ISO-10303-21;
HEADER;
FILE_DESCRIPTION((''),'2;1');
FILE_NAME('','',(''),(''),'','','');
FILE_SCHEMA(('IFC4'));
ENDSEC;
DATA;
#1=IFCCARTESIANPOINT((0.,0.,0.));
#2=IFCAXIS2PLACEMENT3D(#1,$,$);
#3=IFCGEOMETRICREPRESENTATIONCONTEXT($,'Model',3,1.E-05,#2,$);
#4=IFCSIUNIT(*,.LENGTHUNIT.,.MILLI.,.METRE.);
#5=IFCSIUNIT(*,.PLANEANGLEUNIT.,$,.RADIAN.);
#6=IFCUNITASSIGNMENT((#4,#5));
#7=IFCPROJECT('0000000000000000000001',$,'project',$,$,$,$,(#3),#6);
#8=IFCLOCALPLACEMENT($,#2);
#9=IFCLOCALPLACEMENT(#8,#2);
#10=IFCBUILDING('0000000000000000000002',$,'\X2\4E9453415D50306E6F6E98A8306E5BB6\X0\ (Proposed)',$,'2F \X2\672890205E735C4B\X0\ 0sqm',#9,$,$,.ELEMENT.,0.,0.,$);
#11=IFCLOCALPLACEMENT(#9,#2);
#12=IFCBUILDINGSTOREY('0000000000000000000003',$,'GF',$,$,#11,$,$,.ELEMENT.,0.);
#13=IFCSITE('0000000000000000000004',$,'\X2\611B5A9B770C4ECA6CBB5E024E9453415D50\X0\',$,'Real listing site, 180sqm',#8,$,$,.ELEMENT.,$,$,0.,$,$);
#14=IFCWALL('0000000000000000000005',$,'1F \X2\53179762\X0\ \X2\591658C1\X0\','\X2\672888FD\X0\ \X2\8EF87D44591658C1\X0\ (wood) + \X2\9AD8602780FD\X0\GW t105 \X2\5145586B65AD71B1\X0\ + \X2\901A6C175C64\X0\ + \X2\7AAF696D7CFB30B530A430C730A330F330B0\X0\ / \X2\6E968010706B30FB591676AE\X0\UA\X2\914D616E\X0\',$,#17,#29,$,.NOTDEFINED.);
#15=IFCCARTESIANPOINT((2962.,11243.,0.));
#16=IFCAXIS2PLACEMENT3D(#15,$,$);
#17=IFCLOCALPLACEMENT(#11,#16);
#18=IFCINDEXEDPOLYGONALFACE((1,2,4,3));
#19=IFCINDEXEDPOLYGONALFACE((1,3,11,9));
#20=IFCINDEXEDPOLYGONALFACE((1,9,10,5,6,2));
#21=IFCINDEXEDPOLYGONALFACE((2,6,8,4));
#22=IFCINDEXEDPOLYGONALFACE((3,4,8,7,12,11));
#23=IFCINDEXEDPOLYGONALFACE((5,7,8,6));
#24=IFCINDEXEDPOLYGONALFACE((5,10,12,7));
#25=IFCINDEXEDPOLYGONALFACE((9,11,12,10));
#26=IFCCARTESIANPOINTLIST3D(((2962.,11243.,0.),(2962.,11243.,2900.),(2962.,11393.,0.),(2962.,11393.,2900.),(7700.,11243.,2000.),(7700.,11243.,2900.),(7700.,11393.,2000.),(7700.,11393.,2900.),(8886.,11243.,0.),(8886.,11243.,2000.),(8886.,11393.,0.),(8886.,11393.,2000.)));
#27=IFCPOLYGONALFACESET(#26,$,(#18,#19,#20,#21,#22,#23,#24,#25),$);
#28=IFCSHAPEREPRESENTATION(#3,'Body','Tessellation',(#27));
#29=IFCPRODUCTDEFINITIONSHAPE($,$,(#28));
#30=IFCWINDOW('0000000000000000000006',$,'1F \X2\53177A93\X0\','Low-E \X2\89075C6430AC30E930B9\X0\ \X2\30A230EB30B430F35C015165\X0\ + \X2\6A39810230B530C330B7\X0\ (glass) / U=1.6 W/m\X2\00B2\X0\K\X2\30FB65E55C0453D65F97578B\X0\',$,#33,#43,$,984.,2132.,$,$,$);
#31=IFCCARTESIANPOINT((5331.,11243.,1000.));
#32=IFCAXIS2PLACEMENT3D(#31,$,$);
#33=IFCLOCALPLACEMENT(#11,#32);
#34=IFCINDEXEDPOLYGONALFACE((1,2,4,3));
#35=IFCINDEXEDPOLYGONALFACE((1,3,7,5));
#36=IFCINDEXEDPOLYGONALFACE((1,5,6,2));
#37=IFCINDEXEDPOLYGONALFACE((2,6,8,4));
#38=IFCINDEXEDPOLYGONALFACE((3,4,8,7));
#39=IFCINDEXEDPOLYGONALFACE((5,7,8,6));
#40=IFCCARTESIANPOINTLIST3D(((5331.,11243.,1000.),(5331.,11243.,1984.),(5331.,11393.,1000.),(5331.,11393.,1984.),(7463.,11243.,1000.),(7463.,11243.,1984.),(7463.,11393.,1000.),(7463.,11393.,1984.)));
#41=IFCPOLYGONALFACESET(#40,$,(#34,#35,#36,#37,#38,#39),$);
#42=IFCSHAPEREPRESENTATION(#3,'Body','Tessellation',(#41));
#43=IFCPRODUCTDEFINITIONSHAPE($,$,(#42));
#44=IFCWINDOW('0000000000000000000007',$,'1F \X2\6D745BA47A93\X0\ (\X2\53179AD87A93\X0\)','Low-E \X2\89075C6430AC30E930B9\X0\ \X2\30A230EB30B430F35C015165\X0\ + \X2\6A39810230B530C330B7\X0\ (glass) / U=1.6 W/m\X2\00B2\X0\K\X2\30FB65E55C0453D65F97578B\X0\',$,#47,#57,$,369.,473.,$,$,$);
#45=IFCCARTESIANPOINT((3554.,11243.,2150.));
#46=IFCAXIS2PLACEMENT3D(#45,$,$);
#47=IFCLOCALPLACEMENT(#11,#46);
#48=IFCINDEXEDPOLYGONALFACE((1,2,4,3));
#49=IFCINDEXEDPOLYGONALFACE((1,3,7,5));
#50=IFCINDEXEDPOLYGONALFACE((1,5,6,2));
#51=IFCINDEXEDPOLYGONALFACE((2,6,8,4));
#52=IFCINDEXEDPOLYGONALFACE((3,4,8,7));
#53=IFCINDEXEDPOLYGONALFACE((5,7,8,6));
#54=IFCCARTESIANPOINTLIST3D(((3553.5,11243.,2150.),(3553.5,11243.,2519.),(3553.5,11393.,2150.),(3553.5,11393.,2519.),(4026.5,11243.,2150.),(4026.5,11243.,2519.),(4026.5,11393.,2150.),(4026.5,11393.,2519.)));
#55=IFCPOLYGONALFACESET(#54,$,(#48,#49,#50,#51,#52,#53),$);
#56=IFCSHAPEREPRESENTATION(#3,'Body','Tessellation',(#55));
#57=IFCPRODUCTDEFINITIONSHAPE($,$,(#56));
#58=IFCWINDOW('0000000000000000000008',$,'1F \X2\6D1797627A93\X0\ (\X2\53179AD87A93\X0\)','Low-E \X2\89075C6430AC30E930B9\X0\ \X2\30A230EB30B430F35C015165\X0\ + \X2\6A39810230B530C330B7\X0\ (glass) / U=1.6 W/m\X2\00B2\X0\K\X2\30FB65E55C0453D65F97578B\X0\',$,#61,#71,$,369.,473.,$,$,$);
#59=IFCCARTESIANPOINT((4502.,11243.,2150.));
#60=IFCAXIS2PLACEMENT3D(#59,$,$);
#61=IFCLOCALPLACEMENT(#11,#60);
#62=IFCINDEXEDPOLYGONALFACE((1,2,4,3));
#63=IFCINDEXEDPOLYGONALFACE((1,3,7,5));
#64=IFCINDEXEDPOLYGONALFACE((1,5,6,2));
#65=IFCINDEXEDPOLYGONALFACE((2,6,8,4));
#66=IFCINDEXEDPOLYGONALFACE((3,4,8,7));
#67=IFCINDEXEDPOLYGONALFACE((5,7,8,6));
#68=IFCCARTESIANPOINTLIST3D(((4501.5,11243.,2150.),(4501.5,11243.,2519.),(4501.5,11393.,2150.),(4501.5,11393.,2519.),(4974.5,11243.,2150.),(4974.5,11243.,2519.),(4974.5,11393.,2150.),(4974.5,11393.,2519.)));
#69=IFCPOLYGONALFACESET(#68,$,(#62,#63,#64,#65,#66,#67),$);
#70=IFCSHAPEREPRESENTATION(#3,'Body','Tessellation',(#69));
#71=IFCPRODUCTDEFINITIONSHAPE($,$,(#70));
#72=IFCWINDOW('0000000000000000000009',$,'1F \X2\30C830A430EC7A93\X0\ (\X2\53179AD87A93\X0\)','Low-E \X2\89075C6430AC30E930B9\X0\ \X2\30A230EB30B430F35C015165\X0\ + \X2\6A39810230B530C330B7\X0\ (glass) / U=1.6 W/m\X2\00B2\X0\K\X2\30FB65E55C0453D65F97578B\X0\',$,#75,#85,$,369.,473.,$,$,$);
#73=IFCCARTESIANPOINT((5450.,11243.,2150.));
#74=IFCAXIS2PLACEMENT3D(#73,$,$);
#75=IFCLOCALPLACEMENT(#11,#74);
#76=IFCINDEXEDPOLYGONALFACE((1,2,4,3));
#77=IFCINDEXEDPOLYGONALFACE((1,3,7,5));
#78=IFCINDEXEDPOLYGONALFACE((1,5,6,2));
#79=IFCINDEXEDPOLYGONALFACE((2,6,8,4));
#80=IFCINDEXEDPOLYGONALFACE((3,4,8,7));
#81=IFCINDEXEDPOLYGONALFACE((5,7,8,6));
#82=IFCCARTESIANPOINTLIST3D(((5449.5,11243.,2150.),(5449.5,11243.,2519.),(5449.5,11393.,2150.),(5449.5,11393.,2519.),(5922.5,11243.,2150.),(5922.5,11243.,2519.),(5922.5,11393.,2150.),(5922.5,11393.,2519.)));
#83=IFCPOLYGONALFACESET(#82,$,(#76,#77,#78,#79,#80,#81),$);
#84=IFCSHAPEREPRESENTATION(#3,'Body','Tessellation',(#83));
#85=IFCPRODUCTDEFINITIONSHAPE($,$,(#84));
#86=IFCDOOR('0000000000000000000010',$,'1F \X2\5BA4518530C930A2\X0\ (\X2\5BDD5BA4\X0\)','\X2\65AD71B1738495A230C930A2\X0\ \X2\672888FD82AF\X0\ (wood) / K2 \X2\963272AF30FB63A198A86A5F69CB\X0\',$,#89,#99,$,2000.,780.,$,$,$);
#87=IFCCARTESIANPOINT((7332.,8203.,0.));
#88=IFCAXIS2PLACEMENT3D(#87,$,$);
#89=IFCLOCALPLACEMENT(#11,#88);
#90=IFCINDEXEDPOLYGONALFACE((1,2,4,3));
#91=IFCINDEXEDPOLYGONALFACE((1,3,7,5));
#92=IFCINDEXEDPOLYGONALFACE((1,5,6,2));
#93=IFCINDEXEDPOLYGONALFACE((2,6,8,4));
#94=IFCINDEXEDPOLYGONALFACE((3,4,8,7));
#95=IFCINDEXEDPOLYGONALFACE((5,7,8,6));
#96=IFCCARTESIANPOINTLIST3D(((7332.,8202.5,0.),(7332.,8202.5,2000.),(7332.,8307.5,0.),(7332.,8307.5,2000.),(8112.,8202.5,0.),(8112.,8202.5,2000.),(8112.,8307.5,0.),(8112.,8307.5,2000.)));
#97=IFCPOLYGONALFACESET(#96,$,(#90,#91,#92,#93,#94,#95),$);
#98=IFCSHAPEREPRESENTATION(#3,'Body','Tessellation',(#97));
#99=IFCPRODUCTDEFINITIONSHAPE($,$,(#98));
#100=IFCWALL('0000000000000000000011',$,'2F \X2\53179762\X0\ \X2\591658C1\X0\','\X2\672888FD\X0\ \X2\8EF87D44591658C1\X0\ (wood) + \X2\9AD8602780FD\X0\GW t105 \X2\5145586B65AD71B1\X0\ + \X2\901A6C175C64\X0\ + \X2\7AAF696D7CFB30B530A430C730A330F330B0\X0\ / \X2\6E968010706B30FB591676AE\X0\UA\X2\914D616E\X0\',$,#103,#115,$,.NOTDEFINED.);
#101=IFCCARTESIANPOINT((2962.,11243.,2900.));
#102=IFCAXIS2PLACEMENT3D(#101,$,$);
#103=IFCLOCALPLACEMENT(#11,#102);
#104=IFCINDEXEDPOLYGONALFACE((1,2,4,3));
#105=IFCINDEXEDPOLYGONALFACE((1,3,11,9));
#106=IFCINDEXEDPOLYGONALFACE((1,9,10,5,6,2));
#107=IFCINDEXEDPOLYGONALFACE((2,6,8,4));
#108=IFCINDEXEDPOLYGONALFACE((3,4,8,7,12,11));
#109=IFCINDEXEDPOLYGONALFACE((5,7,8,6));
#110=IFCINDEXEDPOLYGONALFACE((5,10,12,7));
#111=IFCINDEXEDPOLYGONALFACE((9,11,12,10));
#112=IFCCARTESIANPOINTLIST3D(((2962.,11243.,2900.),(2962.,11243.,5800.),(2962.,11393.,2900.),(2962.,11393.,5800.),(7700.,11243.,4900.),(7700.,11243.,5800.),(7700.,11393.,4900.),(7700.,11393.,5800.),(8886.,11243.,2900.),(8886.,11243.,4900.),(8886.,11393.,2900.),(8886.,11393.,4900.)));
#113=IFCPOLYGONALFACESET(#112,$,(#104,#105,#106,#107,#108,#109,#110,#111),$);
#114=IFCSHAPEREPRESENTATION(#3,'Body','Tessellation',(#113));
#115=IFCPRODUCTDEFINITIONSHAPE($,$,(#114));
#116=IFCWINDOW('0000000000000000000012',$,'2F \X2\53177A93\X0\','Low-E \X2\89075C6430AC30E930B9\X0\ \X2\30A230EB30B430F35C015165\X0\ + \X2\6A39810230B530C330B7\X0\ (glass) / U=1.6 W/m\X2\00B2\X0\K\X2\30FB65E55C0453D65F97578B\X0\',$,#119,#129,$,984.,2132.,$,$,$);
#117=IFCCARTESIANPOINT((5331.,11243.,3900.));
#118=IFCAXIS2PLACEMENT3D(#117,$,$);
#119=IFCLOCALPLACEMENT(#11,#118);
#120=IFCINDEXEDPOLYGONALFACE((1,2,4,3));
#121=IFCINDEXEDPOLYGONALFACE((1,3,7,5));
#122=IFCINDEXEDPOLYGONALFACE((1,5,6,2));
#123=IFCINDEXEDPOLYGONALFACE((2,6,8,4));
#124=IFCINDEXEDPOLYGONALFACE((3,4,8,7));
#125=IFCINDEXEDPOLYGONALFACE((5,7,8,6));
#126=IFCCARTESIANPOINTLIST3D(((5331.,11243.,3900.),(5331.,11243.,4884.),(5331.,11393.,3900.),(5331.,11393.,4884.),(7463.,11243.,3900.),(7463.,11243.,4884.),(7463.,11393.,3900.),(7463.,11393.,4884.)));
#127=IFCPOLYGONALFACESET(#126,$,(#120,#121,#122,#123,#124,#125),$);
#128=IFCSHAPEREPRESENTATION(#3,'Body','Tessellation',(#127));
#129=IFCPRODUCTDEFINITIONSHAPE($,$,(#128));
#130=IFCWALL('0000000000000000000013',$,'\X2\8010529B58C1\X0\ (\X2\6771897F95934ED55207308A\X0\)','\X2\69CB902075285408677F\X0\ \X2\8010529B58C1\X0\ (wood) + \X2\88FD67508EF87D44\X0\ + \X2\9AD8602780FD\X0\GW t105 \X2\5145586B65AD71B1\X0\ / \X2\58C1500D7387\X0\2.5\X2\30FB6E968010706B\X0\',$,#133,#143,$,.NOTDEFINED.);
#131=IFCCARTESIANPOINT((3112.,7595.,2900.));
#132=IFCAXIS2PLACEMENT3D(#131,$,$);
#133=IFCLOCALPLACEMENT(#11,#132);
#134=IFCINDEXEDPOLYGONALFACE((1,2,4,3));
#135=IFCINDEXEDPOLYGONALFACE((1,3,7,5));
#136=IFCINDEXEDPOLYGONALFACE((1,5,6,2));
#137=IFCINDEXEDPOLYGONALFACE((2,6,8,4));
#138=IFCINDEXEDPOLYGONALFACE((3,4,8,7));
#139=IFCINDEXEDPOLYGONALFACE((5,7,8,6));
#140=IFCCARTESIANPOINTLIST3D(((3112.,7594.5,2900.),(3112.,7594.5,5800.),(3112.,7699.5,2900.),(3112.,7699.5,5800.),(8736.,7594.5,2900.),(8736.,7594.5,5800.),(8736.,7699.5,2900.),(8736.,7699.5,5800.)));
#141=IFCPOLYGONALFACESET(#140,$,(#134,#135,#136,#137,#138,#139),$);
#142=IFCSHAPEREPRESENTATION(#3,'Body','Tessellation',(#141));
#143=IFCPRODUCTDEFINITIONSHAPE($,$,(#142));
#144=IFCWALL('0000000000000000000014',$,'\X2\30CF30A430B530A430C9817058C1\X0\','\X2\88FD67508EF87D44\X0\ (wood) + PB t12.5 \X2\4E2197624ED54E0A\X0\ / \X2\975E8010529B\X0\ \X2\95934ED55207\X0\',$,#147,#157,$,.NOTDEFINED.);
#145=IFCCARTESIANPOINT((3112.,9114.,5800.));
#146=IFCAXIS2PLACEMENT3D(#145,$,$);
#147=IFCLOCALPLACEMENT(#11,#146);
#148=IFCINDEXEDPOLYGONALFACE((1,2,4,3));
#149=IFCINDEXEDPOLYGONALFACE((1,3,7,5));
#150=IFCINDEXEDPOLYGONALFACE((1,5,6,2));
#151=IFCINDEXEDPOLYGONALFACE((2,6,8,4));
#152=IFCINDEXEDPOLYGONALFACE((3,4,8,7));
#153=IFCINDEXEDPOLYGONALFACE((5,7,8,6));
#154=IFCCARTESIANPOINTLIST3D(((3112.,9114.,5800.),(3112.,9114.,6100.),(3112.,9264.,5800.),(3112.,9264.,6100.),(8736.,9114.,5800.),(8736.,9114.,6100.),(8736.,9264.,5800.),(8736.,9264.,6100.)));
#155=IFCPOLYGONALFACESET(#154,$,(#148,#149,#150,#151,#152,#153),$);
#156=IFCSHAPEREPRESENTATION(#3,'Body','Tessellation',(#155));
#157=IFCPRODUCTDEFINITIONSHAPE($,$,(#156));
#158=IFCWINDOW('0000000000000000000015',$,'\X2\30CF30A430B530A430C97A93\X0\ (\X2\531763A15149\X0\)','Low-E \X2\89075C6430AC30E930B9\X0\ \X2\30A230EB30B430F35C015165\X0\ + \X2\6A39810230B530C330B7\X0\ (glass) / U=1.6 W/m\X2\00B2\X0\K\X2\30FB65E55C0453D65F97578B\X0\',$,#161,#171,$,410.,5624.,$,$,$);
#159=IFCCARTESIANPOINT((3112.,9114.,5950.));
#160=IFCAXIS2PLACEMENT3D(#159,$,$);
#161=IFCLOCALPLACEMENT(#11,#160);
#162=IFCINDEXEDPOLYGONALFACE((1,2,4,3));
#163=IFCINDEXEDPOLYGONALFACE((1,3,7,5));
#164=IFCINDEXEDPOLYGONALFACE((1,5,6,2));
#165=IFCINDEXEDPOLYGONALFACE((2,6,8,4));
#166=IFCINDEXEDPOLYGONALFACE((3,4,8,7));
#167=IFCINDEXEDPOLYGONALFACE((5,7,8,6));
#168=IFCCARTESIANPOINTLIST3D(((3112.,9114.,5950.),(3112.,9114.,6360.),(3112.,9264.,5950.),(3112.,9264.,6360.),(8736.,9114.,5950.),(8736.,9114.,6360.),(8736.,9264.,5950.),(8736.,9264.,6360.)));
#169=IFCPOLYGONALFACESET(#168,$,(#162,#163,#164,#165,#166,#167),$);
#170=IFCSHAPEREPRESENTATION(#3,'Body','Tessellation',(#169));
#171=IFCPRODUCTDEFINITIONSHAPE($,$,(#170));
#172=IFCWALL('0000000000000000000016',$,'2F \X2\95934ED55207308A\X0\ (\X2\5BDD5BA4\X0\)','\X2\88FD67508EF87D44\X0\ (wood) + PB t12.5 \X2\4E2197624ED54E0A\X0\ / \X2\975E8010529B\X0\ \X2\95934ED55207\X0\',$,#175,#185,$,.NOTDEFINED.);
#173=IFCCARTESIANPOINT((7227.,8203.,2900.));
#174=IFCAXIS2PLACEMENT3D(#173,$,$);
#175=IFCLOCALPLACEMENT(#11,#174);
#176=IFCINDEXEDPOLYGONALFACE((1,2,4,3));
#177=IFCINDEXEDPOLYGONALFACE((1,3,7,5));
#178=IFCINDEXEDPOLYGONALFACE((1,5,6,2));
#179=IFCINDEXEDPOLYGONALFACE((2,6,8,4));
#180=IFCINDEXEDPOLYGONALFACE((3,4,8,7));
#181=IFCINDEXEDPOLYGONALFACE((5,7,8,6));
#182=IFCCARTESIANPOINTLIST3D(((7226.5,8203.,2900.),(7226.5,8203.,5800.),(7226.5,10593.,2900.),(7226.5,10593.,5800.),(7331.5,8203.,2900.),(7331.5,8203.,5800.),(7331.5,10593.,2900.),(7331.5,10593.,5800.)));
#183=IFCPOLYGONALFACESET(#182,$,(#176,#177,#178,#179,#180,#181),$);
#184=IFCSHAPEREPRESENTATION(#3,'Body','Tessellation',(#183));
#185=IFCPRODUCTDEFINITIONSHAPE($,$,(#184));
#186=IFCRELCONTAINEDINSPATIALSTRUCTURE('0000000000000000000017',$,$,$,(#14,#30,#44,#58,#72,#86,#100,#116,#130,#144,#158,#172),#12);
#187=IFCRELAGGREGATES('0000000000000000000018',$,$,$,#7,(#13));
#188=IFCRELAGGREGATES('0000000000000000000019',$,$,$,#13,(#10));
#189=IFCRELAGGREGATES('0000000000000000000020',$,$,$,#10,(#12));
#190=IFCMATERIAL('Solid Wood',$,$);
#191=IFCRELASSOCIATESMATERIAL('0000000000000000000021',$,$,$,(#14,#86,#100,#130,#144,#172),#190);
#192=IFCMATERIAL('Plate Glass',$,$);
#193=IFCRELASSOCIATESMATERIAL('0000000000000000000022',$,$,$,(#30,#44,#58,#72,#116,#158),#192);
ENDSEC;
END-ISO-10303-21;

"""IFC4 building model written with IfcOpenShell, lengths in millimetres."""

from ifc_helpers import new_model, si_unit, frame, frame_2d, origin, place, context, project, spatial, rectangle, extrude, material, element, fill, save


model = new_model("IFC4")

# Units and contexts
model_context = context("Model", 3, precision=1e-05, world=origin())
ifc_project = project(units=[si_unit("LENGTHUNIT", "METRE", prefix="MILLI"), si_unit("PLANEANGLEUNIT", "RADIAN")], contexts=[model_context])

# Site, building, storey
site_placement = place(None, origin())
site = spatial("IfcSite", under=ifc_project, at=site_placement, Name="愛媛県今治市五十嵐", ObjectType="Real listing site, 180sqm", CompositionType="ELEMENT", RefElevation=0.0)
building_placement = place(site_placement, origin())
building = spatial("IfcBuilding", under=site, at=building_placement, Name="五十嵐の潮風の家 (Proposed)", ObjectType="2F 木造平屋 0sqm", CompositionType="ELEMENT", ElevationOfRefHeight=0.0, ElevationOfTerrain=0.0)
storey_placement = place(building_placement, origin())
storey = spatial("IfcBuildingStorey", under=building, at=storey_placement, Name="GF", CompositionType="ELEMENT", Elevation=0.0)

# Wall, openings, windows
ifc_material_1 = material(Name="Solid Wood")
wall_1_placement = place(storey_placement, frame((2962.0, 11243.0, 0.0)))
wall_1 = element("IfcWall", 1, at=wall_1_placement, inside=storey, material=ifc_material_1, Name="1F 北面 外壁", Description="木製 軸組外壁 (wood) + 高性能GW t105 充填断熱 + 通気層 + 窯業系サイディング / 準耐火・外皮UA配慮", PredefinedType="NOTDEFINED", context=model_context, shape_type="SweptSolid", body=[
    extrude(rectangle(XDim=5924.0, YDim=150.0, at=frame_2d((2962.0, 75.0))), frame((2962.0, 11243.0, 0.0)), (0.0, 0.0, 1.0), 2900.0),
])
opening_1_placement = place(storey_placement, frame((5331.0, 11243.0, 1000.0)))
opening_1 = element("IfcOpeningElement", 2, at=opening_1_placement, cuts=wall_1, PredefinedType="NOTDEFINED", context=model_context, shape_type="SweptSolid", body=[
    extrude(rectangle(XDim=2132.0, YDim=150.0, at=frame_2d((1066.0, 75.0))), frame((5331.0, 11243.0, 1000.0)), (0.0, 0.0, 1.0), 984.0),
])
opening_2_placement = place(storey_placement, frame((3554.0, 11243.0, 2150.0)))
opening_2 = element("IfcOpeningElement", 3, at=opening_2_placement, cuts=wall_1, PredefinedType="NOTDEFINED", context=model_context, shape_type="SweptSolid", body=[
    extrude(rectangle(XDim=473.0, YDim=150.0, at=frame_2d((236.0, 75.0))), frame((3554.0, 11243.0, 2150.0)), (0.0, 0.0, 1.0), 369.0),
])
opening_3_placement = place(storey_placement, frame((4502.0, 11243.0, 2150.0)))
opening_3 = element("IfcOpeningElement", 4, at=opening_3_placement, cuts=wall_1, PredefinedType="NOTDEFINED", context=model_context, shape_type="SweptSolid", body=[
    extrude(rectangle(XDim=473.0, YDim=150.0, at=frame_2d((236.0, 75.0))), frame((4502.0, 11243.0, 2150.0)), (0.0, 0.0, 1.0), 369.0),
])
opening_4_placement = place(storey_placement, frame((5450.0, 11243.0, 2150.0)))
opening_4 = element("IfcOpeningElement", 5, at=opening_4_placement, cuts=wall_1, PredefinedType="NOTDEFINED", context=model_context, shape_type="SweptSolid", body=[
    extrude(rectangle(XDim=473.0, YDim=150.0, at=frame_2d((236.0, 75.0))), frame((5450.0, 11243.0, 2150.0)), (0.0, 0.0, 1.0), 369.0),
])
ifc_material_2 = material(Name="Plate Glass")
window_1_placement = place(storey_placement, frame((5331.0, 11243.0, 1000.0)))
window_1 = element("IfcWindow", 6, at=window_1_placement, inside=storey, material=ifc_material_2, Name="1F 北窓", Description="Low-E 複層ガラス アルゴン封入 + 樹脂サッシ (glass) / U=1.6 W/m²K・日射取得型", OverallHeight=984.0, OverallWidth=2132.0, context=model_context, shape_type="SweptSolid", body=[
    extrude(rectangle(XDim=2132.0, YDim=150.0, at=frame_2d((1066.0, 75.0))), frame((5331.0, 11243.0, 1000.0)), (0.0, 0.0, 1.0), 984.0),
])
fill(opening_1, window_1)
window_2_placement = place(storey_placement, frame((3554.0, 11243.0, 2150.0)))
window_2 = element("IfcWindow", 7, at=window_2_placement, inside=storey, material=ifc_material_2, Name="1F 浴室窓 (北高窓)", Description="Low-E 複層ガラス アルゴン封入 + 樹脂サッシ (glass) / U=1.6 W/m²K・日射取得型", OverallHeight=369.0, OverallWidth=473.0, context=model_context, shape_type="SweptSolid", body=[
    extrude(rectangle(XDim=473.0, YDim=150.0, at=frame_2d((236.0, 75.0))), frame((3554.0, 11243.0, 2150.0)), (0.0, 0.0, 1.0), 369.0),
])
fill(opening_2, window_2)
window_3_placement = place(storey_placement, frame((4502.0, 11243.0, 2150.0)))
window_3 = element("IfcWindow", 8, at=window_3_placement, inside=storey, material=ifc_material_2, Name="1F 洗面窓 (北高窓)", Description="Low-E 複層ガラス アルゴン封入 + 樹脂サッシ (glass) / U=1.6 W/m²K・日射取得型", OverallHeight=369.0, OverallWidth=473.0, context=model_context, shape_type="SweptSolid", body=[
    extrude(rectangle(XDim=473.0, YDim=150.0, at=frame_2d((236.0, 75.0))), frame((4502.0, 11243.0, 2150.0)), (0.0, 0.0, 1.0), 369.0),
])
fill(opening_3, window_3)
window_4_placement = place(storey_placement, frame((5450.0, 11243.0, 2150.0)))
window_4 = element("IfcWindow", 9, at=window_4_placement, inside=storey, material=ifc_material_2, Name="1F トイレ窓 (北高窓)", Description="Low-E 複層ガラス アルゴン封入 + 樹脂サッシ (glass) / U=1.6 W/m²K・日射取得型", OverallHeight=369.0, OverallWidth=473.0, context=model_context, shape_type="SweptSolid", body=[
    extrude(rectangle(XDim=473.0, YDim=150.0, at=frame_2d((236.0, 75.0))), frame((5450.0, 11243.0, 2150.0)), (0.0, 0.0, 1.0), 369.0),
])
fill(opening_4, window_4)

# Door
door_1_placement = place(storey_placement, frame((7332.0, 8203.0, 0.0)))
element("IfcDoor", 10, at=door_1_placement, inside=storey, material=ifc_material_1, Name="1F 室内ドア (寝室)", Description="断熱玄関ドア 木製芯 (wood) / K2 防犯・採風機構", OverallHeight=2000.0, OverallWidth=780.0, context=model_context, shape_type="SweptSolid", body=[
    extrude(rectangle(XDim=780.0, YDim=105.0, at=frame_2d((390.0, 52.0))), frame((7332.0, 8203.0, 0.0)), (0.0, 0.0, 1.0), 2000.0),
])

# Wall, opening, window
wall_2_placement = place(storey_placement, frame((2962.0, 11243.0, 2900.0)))
wall_2 = element("IfcWall", 11, at=wall_2_placement, inside=storey, material=ifc_material_1, Name="2F 北面 外壁", Description="木製 軸組外壁 (wood) + 高性能GW t105 充填断熱 + 通気層 + 窯業系サイディング / 準耐火・外皮UA配慮", PredefinedType="NOTDEFINED", context=model_context, shape_type="SweptSolid", body=[
    extrude(rectangle(XDim=5924.0, YDim=150.0, at=frame_2d((2962.0, 75.0))), frame((2962.0, 11243.0, 2900.0)), (0.0, 0.0, 1.0), 2900.0),
])
opening_5_placement = place(storey_placement, frame((5331.0, 11243.0, 3900.0)))
opening_5 = element("IfcOpeningElement", 12, at=opening_5_placement, cuts=wall_2, PredefinedType="NOTDEFINED", context=model_context, shape_type="SweptSolid", body=[
    extrude(rectangle(XDim=2132.0, YDim=150.0, at=frame_2d((1066.0, 75.0))), frame((5331.0, 11243.0, 3900.0)), (0.0, 0.0, 1.0), 984.0),
])
window_5_placement = place(storey_placement, frame((5331.0, 11243.0, 3900.0)))
window_5 = element("IfcWindow", 13, at=window_5_placement, inside=storey, material=ifc_material_2, Name="2F 北窓", Description="Low-E 複層ガラス アルゴン封入 + 樹脂サッシ (glass) / U=1.6 W/m²K・日射取得型", OverallHeight=984.0, OverallWidth=2132.0, context=model_context, shape_type="SweptSolid", body=[
    extrude(rectangle(XDim=2132.0, YDim=150.0, at=frame_2d((1066.0, 75.0))), frame((5331.0, 11243.0, 3900.0)), (0.0, 0.0, 1.0), 984.0),
])
fill(opening_5, window_5)

# Wall
wall_3_placement = place(storey_placement, frame((3112.0, 7595.0, 2900.0)))
element("IfcWall", 14, at=wall_3_placement, inside=storey, material=ifc_material_1, Name="耐力壁 (東西間仕切り)", Description="構造用合板 耐力壁 (wood) + 製材軸組 + 高性能GW t105 充填断熱 / 壁倍率2.5・準耐火", PredefinedType="NOTDEFINED", context=model_context, shape_type="SweptSolid", body=[
    extrude(rectangle(XDim=5624.0, YDim=105.0, at=frame_2d((2812.0, 52.0))), frame((3112.0, 7595.0, 2900.0)), (0.0, 0.0, 1.0), 2900.0),
])

# Wall, opening, window
wall_4_placement = place(storey_placement, frame((3112.0, 9114.0, 5800.0)))
wall_4 = element("IfcWall", 15, at=wall_4_placement, inside=storey, material=ifc_material_1, Name="ハイサイド腰壁", Description="製材軸組 (wood) + PB t12.5 両面仕上 / 非耐力 間仕切", PredefinedType="NOTDEFINED", context=model_context, shape_type="SweptSolid", body=[
    extrude(rectangle(XDim=5624.0, YDim=150.0, at=frame_2d((2812.0, 75.0))), frame((3112.0, 9114.0, 5800.0)), (0.0, 0.0, 1.0), 700.0),
])
opening_6_placement = place(storey_placement, frame((3112.0, 9114.0, 5950.0)))
opening_6 = element("IfcOpeningElement", 16, at=opening_6_placement, cuts=wall_4, PredefinedType="NOTDEFINED", context=model_context, shape_type="SweptSolid", body=[
    extrude(rectangle(XDim=5624.0, YDim=150.0, at=frame_2d((2812.0, 75.0))), frame((3112.0, 9114.0, 5950.0)), (0.0, 0.0, 1.0), 410.0),
])
window_6_placement = place(storey_placement, frame((3112.0, 9114.0, 5950.0)))
window_6 = element("IfcWindow", 17, at=window_6_placement, inside=storey, material=ifc_material_2, Name="ハイサイド窓 (北採光)", Description="Low-E 複層ガラス アルゴン封入 + 樹脂サッシ (glass) / U=1.6 W/m²K・日射取得型", OverallHeight=410.0, OverallWidth=5624.0, context=model_context, shape_type="SweptSolid", body=[
    extrude(rectangle(XDim=5624.0, YDim=150.0, at=frame_2d((2812.0, 75.0))), frame((3112.0, 9114.0, 5950.0)), (0.0, 0.0, 1.0), 410.0),
])
fill(opening_6, window_6)

# Wall
wall_5_placement = place(storey_placement, frame((7227.0, 8203.0, 2900.0)))
element("IfcWall", 18, at=wall_5_placement, inside=storey, material=ifc_material_1, Name="2F 間仕切り (寝室)", Description="製材軸組 (wood) + PB t12.5 両面仕上 / 非耐力 間仕切", PredefinedType="NOTDEFINED", context=model_context, shape_type="SweptSolid", body=[
    extrude(rectangle(XDim=105.0, YDim=2390.0, at=frame_2d((52.0, 1195.0))), frame((7227.0, 8203.0, 2900.0)), (0.0, 0.0, 1.0), 2900.0),
])

save(model, "model.ifc")
